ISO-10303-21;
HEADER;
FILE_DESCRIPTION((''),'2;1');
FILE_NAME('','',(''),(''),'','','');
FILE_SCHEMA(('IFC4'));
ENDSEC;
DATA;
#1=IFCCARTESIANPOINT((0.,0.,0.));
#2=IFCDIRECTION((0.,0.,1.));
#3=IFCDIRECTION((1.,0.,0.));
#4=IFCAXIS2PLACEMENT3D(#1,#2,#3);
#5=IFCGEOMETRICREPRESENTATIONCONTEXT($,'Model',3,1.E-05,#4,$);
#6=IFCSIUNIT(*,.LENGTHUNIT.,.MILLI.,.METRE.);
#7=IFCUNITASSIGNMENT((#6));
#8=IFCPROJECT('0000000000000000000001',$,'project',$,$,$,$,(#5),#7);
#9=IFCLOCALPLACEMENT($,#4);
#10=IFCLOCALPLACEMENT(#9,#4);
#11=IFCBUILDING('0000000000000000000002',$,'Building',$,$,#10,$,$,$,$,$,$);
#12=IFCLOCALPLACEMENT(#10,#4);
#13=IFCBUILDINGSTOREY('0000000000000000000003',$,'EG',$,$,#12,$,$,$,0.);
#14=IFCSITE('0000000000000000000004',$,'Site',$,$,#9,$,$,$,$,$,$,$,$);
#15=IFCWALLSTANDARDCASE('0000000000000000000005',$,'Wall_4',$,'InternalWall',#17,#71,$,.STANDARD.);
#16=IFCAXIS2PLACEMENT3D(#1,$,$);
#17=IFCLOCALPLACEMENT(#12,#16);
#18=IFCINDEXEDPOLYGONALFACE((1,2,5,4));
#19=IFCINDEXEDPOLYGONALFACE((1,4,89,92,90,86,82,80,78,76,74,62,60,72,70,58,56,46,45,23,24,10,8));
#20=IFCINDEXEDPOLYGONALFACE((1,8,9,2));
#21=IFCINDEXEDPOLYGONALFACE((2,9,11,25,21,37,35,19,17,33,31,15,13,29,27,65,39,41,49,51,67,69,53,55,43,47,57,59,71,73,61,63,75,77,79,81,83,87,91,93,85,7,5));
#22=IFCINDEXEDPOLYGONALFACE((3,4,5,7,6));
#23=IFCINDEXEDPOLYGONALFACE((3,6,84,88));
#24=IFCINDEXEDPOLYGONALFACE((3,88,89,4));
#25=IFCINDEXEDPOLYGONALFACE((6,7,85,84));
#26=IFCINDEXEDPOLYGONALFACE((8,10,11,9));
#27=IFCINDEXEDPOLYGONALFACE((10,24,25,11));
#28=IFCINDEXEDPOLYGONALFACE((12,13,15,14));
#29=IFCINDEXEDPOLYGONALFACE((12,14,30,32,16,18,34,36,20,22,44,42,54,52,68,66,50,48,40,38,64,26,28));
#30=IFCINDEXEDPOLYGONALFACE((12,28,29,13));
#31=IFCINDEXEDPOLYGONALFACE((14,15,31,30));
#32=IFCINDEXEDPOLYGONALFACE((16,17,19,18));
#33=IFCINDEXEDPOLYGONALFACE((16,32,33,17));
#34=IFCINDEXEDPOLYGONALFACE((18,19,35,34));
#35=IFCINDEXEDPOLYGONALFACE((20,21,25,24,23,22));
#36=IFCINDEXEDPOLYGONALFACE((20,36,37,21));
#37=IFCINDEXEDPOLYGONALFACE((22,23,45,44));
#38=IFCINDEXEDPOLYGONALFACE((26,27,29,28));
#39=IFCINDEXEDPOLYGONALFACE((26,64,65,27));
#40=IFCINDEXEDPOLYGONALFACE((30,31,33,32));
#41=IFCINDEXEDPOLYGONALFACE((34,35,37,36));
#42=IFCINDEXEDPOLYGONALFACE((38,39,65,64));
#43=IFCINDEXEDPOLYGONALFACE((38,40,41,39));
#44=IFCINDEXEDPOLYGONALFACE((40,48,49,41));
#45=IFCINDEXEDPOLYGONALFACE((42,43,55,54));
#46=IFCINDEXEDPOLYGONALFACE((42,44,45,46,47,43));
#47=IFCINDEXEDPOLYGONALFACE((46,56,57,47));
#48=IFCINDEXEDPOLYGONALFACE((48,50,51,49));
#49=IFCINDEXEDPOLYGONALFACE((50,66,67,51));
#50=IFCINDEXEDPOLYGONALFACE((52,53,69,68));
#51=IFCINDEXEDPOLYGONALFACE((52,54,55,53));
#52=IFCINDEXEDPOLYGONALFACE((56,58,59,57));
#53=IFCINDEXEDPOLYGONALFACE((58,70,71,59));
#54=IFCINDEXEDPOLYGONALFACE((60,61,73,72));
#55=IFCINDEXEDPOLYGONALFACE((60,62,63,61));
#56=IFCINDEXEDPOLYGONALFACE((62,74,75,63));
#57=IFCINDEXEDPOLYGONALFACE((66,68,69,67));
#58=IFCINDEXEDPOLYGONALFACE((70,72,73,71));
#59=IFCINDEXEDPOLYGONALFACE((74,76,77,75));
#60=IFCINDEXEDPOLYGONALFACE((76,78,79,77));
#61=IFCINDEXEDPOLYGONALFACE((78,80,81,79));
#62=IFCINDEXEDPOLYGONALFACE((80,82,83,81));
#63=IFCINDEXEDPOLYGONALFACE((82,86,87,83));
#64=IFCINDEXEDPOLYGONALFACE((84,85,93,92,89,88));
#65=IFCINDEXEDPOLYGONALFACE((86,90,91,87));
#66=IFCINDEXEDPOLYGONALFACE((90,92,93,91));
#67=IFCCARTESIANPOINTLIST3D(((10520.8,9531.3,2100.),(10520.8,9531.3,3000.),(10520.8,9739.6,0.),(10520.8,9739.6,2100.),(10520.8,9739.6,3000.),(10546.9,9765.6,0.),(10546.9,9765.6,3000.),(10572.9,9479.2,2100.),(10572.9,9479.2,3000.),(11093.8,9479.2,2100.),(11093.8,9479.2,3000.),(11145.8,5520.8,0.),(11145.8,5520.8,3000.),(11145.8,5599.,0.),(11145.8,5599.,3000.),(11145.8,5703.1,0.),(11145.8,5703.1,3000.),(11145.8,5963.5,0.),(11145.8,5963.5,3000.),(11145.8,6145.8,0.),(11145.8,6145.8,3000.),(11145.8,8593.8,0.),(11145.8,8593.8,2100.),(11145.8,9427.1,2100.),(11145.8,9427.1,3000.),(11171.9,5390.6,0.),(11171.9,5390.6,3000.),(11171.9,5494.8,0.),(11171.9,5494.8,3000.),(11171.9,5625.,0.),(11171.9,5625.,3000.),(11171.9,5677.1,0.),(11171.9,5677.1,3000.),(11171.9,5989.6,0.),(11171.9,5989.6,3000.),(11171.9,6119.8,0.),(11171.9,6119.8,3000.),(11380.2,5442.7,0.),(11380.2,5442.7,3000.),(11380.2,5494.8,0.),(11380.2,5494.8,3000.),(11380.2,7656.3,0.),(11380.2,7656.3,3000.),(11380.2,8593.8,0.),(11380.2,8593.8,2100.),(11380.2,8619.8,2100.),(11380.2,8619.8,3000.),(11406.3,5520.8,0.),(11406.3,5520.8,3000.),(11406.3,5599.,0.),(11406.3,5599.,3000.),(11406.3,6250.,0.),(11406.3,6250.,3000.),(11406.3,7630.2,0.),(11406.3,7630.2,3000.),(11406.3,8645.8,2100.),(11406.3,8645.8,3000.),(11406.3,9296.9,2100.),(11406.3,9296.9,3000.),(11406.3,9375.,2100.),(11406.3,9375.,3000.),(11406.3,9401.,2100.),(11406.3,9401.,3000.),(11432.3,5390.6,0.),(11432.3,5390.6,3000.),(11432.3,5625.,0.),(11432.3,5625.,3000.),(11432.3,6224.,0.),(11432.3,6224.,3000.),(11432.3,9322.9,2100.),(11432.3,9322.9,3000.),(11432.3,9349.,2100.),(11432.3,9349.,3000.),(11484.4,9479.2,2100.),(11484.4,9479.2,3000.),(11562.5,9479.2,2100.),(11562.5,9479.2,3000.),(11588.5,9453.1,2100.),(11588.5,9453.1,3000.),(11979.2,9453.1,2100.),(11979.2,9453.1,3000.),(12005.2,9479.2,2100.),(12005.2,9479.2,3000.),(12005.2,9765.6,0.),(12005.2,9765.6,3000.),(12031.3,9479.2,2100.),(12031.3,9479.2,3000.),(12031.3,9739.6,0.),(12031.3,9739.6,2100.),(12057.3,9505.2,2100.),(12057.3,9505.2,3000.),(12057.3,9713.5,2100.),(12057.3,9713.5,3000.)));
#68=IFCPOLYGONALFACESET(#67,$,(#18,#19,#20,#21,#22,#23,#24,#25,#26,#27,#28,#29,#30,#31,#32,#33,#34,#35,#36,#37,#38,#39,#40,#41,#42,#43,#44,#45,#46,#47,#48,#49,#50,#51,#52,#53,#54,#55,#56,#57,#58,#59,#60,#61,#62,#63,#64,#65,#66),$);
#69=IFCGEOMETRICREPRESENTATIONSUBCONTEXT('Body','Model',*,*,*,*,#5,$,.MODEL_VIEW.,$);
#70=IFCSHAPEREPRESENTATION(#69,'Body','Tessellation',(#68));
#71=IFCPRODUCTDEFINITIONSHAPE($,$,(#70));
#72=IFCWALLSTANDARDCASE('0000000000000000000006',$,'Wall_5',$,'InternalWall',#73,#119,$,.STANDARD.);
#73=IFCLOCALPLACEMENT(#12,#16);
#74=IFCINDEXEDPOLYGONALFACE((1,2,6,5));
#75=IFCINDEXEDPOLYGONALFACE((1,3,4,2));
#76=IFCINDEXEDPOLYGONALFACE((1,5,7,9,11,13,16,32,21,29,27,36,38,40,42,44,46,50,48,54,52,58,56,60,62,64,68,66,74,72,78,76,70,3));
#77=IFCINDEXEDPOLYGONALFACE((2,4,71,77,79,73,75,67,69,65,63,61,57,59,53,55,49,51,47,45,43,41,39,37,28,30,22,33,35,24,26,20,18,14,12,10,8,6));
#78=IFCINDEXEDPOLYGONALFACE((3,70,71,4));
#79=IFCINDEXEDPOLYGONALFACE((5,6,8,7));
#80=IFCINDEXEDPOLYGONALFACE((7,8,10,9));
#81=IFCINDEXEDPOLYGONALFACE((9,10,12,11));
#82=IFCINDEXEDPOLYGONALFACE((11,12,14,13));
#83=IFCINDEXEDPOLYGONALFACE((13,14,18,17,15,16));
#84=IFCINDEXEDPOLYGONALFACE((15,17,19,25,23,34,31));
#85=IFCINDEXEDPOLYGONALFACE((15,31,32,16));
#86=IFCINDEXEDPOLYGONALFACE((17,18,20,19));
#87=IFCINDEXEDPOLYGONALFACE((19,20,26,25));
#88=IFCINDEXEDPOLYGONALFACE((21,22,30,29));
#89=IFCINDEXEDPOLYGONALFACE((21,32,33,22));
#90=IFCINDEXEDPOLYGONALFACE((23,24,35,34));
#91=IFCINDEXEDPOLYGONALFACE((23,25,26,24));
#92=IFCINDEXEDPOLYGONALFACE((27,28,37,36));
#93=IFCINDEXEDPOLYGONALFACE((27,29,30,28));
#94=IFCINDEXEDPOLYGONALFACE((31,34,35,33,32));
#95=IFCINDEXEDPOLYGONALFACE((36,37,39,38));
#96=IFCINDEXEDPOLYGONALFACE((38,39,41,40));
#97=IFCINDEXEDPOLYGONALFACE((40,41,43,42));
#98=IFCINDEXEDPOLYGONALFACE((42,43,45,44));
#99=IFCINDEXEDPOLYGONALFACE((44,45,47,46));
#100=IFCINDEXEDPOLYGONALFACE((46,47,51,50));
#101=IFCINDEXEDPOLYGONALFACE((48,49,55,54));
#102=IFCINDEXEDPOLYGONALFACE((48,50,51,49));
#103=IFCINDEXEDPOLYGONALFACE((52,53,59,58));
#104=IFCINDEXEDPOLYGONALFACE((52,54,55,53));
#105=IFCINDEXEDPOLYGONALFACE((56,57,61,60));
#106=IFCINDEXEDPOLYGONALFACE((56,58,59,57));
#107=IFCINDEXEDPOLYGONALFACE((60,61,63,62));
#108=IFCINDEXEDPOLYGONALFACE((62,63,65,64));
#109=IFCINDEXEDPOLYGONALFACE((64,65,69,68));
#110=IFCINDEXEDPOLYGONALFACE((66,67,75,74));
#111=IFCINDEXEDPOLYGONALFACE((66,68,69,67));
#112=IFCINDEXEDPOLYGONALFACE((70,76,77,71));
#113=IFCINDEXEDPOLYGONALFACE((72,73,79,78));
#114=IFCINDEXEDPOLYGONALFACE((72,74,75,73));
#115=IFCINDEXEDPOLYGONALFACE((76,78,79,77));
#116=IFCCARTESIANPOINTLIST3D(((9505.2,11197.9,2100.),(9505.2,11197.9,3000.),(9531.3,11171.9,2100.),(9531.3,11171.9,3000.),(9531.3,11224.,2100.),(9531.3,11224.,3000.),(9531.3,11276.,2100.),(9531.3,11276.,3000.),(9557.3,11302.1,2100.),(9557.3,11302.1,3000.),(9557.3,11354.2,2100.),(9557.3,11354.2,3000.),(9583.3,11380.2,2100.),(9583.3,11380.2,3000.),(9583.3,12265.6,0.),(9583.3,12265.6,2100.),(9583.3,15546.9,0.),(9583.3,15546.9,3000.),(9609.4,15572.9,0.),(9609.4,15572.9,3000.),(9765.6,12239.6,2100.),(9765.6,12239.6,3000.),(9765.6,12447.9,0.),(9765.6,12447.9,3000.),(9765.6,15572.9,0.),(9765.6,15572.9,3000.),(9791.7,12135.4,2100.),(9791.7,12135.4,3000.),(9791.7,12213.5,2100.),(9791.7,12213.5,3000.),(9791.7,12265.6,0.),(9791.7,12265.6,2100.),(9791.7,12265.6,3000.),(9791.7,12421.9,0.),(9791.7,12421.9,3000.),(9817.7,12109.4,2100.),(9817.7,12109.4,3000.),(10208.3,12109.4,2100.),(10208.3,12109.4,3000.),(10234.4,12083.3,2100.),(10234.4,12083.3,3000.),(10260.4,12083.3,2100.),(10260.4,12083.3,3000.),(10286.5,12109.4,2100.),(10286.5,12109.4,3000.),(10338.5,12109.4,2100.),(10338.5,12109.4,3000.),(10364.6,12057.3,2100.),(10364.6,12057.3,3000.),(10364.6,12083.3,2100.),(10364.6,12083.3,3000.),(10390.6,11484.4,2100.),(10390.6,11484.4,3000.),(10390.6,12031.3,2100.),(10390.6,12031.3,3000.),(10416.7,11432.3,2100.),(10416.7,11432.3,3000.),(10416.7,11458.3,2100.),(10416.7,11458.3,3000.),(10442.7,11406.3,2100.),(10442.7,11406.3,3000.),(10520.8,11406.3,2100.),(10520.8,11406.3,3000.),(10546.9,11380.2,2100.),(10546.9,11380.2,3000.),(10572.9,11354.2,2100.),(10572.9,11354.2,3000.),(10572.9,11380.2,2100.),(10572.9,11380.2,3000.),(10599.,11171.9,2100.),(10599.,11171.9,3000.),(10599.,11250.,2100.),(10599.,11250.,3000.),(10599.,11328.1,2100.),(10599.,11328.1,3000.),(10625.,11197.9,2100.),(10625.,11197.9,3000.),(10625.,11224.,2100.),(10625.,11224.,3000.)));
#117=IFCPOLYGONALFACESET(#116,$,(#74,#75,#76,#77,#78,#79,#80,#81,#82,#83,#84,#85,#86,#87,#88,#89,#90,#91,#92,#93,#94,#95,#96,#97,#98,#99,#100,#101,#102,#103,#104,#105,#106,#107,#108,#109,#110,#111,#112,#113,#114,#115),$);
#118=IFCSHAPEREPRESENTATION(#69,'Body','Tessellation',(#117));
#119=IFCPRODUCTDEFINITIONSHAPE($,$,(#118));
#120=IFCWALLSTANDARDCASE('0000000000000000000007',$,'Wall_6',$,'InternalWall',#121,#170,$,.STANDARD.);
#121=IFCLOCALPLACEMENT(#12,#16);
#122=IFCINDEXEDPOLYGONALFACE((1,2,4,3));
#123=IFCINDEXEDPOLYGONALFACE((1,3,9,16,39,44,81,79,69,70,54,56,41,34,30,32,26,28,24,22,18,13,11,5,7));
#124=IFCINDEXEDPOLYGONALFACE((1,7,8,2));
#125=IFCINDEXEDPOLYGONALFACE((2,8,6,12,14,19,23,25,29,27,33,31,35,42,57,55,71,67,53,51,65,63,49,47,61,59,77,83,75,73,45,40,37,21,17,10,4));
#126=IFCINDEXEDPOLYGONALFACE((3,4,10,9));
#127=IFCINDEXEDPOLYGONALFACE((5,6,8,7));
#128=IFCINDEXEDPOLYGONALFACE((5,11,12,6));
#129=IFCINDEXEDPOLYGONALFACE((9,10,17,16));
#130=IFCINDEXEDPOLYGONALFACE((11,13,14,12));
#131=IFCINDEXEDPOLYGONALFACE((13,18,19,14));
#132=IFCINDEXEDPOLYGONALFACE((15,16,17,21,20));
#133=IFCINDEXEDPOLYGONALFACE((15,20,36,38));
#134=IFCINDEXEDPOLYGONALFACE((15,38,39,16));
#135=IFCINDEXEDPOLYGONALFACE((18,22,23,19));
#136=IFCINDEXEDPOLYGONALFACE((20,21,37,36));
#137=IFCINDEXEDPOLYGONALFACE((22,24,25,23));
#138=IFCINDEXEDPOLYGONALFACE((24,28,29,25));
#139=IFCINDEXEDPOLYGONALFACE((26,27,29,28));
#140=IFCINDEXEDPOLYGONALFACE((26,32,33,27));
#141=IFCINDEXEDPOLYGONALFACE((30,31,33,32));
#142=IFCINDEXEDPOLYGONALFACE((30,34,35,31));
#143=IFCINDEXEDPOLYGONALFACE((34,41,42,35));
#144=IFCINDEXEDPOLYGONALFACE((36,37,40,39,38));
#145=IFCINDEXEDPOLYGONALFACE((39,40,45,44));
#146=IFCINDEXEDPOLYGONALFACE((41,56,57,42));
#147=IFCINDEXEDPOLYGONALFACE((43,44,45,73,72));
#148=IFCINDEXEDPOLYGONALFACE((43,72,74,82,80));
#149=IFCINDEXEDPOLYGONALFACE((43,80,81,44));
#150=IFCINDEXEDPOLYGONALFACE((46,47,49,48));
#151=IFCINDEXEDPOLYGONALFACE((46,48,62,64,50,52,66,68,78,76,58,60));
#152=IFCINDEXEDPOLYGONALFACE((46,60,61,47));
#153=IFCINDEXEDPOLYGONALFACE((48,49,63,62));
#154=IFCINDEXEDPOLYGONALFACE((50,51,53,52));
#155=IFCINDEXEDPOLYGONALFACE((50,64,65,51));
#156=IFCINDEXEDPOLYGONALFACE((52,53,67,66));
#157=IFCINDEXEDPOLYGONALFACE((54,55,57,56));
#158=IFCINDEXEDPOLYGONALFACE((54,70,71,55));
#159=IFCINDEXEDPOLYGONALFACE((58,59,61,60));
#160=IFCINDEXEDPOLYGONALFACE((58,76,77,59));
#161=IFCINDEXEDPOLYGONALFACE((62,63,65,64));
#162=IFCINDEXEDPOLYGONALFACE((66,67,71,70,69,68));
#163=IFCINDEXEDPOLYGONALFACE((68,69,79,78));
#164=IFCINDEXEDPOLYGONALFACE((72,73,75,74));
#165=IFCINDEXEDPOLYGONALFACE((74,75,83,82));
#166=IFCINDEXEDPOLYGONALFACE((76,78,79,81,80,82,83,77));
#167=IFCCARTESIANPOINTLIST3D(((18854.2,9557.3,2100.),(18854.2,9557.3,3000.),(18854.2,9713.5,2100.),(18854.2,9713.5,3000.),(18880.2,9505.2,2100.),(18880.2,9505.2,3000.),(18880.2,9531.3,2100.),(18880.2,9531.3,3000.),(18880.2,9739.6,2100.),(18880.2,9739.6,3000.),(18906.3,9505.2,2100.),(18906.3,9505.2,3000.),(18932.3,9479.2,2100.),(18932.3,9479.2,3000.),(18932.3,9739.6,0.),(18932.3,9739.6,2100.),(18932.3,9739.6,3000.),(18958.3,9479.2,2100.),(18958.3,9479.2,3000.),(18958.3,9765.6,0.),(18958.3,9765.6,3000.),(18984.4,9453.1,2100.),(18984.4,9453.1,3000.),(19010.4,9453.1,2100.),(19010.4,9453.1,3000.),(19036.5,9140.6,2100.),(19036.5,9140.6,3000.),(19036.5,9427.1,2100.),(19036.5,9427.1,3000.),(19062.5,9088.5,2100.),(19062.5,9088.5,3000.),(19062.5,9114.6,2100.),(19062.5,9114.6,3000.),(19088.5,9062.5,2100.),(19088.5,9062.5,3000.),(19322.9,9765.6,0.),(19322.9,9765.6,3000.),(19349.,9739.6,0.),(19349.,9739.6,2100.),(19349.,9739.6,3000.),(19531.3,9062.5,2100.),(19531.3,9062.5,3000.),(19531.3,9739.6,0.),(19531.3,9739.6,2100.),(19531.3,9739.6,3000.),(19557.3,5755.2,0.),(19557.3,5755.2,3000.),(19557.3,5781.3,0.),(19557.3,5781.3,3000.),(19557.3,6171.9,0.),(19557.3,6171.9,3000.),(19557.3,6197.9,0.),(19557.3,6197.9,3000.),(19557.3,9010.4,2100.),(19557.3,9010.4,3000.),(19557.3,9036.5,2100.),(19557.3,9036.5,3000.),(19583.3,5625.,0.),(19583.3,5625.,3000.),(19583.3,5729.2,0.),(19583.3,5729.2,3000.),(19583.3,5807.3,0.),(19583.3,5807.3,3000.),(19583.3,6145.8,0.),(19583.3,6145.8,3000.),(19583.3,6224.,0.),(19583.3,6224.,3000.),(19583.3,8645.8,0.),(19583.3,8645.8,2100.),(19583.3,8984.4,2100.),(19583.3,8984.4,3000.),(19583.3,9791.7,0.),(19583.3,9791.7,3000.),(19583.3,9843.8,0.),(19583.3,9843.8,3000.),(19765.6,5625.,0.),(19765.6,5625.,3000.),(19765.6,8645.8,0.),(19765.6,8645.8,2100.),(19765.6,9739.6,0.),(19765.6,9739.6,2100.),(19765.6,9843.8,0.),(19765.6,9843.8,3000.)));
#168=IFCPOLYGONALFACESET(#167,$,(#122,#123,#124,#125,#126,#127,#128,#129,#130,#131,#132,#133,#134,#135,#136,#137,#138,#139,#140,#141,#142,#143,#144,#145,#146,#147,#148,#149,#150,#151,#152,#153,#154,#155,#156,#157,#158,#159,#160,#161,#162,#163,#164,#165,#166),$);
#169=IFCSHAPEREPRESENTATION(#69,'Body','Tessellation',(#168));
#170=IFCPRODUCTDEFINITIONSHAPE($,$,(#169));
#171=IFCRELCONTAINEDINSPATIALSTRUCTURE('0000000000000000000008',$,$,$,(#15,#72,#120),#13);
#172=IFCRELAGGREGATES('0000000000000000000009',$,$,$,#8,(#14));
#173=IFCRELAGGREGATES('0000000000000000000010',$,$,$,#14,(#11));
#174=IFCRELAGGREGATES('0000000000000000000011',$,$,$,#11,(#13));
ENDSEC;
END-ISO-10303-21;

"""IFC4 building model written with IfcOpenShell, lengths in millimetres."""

from ifc_helpers import new_model, si_unit, frame, origin_with_axes, place, context, subcontext, project, spatial, polyline, rectangle, outline, extrude, element, save


model = new_model("IFC4")

# Units and contexts
model_context = context("Model", 3, precision=1e-05, world=origin_with_axes())
body_context = subcontext(model_context, "Body", "Model", "MODEL_VIEW")
ifc_project = project(units=[si_unit("LENGTHUNIT", "METRE", prefix="MILLI")], contexts=[model_context])

# Site, building, storey
site_placement = place(None, origin_with_axes())
site = spatial("IfcSite", under=ifc_project, at=site_placement, Name="Site")
building_placement = place(site_placement, origin_with_axes())
building = spatial("IfcBuilding", under=site, at=building_placement, Name="Building")
storey_placement = place(building_placement, origin_with_axes())
storey = spatial("IfcBuildingStorey", under=building, at=storey_placement, Name="EG", Elevation=0.0)

# Walls, openings
wall_1_placement = place(storey_placement, origin_with_axes())
wall_1 = element("IfcWallStandardCase", 1, at=wall_1_placement, inside=storey, Name="Wall_4", ObjectType="InternalWall", PredefinedType="STANDARD", context=body_context, shape_type="SweptSolid", body=[
    extrude(outline(polyline([(11171.9, 5390.6, 0.0), (11171.9, 5494.8, 0.0), (11145.8, 5520.8, 0.0), (11145.8, 5599.0, 0.0), (11171.9, 5625.0, 0.0), (11171.9, 5677.1, 0.0), (11145.8, 5703.1, 0.0), (11145.8, 5963.5, 0.0), (11171.9, 5989.6, 0.0), (11171.9, 6119.8, 0.0), (11145.8, 6145.8, 0.0), (11145.8, 9427.1, 0.0), (11093.8, 9479.2, 0.0), (10572.9, 9479.2, 0.0), (10520.8, 9531.3, 0.0), (10520.8, 9739.6, 0.0), (10546.9, 9765.6, 0.0), (12005.2, 9765.6, 0.0), (12057.3, 9713.5, 0.0), (12057.3, 9505.2, 0.0), (12031.3, 9479.2, 0.0), (12005.2, 9479.2, 0.0), (11979.2, 9453.1, 0.0), (11588.5, 9453.1, 0.0), (11562.5, 9479.2, 0.0), (11484.4, 9479.2, 0.0), (11406.3, 9401.0, 0.0), (11406.3, 9375.0, 0.0), (11432.3, 9349.0, 0.0), (11432.3, 9322.9, 0.0), (11406.3, 9296.9, 0.0), (11406.3, 8645.8, 0.0), (11380.2, 8619.8, 0.0), (11380.2, 7656.3, 0.0), (11406.3, 7630.2, 0.0), (11406.3, 6250.0, 0.0), (11432.3, 6224.0, 0.0), (11432.3, 5625.0, 0.0), (11406.3, 5599.0, 0.0), (11406.3, 5520.8, 0.0), (11380.2, 5494.8, 0.0), (11380.2, 5442.7, 0.0), (11432.3, 5390.6, 0.0), (11562.5, 5390.6, 0.0), (11171.9, 5390.6, 0.0)])), origin_with_axes(), (0.0, 0.0, 1.0), 3000.0),
])
opening_1_placement = place(wall_1_placement, origin_with_axes())
element("IfcOpeningElement", 2, at=opening_1_placement, inside=storey, cuts=wall_1, context=body_context, shape_type="SweptSolid", body=[
    extrude(rectangle(XDim=1145.8, YDim=1536.5), frame((11289.1, 9166.7, 0.0), z_axis=(0.0, 0.0, 1.0), x_axis=(0.0, 1.0, 0.0)), (0.0, 0.0, 1.0), 2100.0),
])
wall_2_placement = place(storey_placement, origin_with_axes())
wall_2 = element("IfcWallStandardCase", 3, at=wall_2_placement, inside=storey, Name="Wall_5", ObjectType="InternalWall", PredefinedType="STANDARD", context=body_context, shape_type="SweptSolid", body=[
    extrude(outline(polyline([(9531.3, 11171.9, 0.0), (9505.2, 11197.9, 0.0), (9531.3, 11224.0, 0.0), (9531.3, 11276.0, 0.0), (9557.3, 11302.1, 0.0), (9557.3, 11354.2, 0.0), (9583.3, 11380.2, 0.0), (9583.3, 15546.9, 0.0), (9609.4, 15572.9, 0.0), (9765.6, 15572.9, 0.0), (9765.6, 12447.9, 0.0), (9791.7, 12421.9, 0.0), (9791.7, 12265.6, 0.0), (9765.6, 12239.6, 0.0), (9791.7, 12213.5, 0.0), (9791.7, 12135.4, 0.0), (9817.7, 12109.4, 0.0), (10208.3, 12109.4, 0.0), (10234.4, 12083.3, 0.0), (10260.4, 12083.3, 0.0), (10286.5, 12109.4, 0.0), (10338.5, 12109.4, 0.0), (10364.6, 12083.3, 0.0), (10364.6, 12057.3, 0.0), (10390.6, 12031.3, 0.0), (10390.6, 11484.4, 0.0), (10416.7, 11458.3, 0.0), (10416.7, 11432.3, 0.0), (10442.7, 11406.3, 0.0), (10520.8, 11406.3, 0.0), (10546.9, 11380.2, 0.0), (10572.9, 11380.2, 0.0), (10572.9, 11354.2, 0.0), (10599.0, 11328.1, 0.0), (10599.0, 11250.0, 0.0), (10625.0, 11224.0, 0.0), (10625.0, 11197.9, 0.0), (10599.0, 11171.9, 0.0), (9531.3, 11171.9, 0.0)])), origin_with_axes(), (0.0, 0.0, 1.0), 3000.0),
])
opening_2_placement = place(wall_2_placement, origin_with_axes())
element("IfcOpeningElement", 4, at=opening_2_placement, inside=storey, cuts=wall_2, context=body_context, shape_type="SweptSolid", body=[
    extrude(rectangle(XDim=1093.8, YDim=1119.8), frame((10065.1, 11718.8, 0.0), z_axis=(0.0, 0.0, 1.0), x_axis=(0.0, -1.0, 0.0)), (0.0, 0.0, 1.0), 2100.0),
])
wall_3_placement = place(storey_placement, origin_with_axes())
wall_3 = element("IfcWallStandardCase", 5, at=wall_3_placement, inside=storey, Name="Wall_6", ObjectType="InternalWall", PredefinedType="STANDARD", context=body_context, shape_type="SweptSolid", body=[
    extrude(outline(polyline([(19583.3, 5625.0, 0.0), (19583.3, 5729.2, 0.0), (19557.3, 5755.2, 0.0), (19557.3, 5781.3, 0.0), (19583.3, 5807.3, 0.0), (19583.3, 6145.8, 0.0), (19557.3, 6171.9, 0.0), (19557.3, 6197.9, 0.0), (19583.3, 6224.0, 0.0), (19583.3, 8984.4, 0.0), (19557.3, 9010.4, 0.0), (19557.3, 9036.5, 0.0), (19531.3, 9062.5, 0.0), (19088.5, 9062.5, 0.0), (19062.5, 9088.5, 0.0), (19062.5, 9114.6, 0.0), (19036.5, 9140.6, 0.0), (19036.5, 9427.1, 0.0), (19010.4, 9453.1, 0.0), (18984.4, 9453.1, 0.0), (18958.3, 9479.2, 0.0), (18932.3, 9479.2, 0.0), (18906.3, 9505.2, 0.0), (18880.2, 9505.2, 0.0), (18880.2, 9531.3, 0.0), (18854.2, 9557.3, 0.0), (18854.2, 9713.5, 0.0), (18880.2, 9739.6, 0.0), (18932.3, 9739.6, 0.0), (18958.3, 9765.6, 0.0), (19322.9, 9765.6, 0.0), (19349.0, 9739.6, 0.0), (19531.3, 9739.6, 0.0), (19583.3, 9791.7, 0.0), (19583.3, 9843.8, 0.0), (19765.6, 9843.8, 0.0), (19765.6, 5625.0, 0.0), (19583.3, 5625.0, 0.0)])), origin_with_axes(), (0.0, 0.0, 1.0), 3000.0),
])
opening_3_placement = place(wall_3_placement, origin_with_axes())
element("IfcOpeningElement", 6, at=opening_3_placement, inside=storey, cuts=wall_3, context=body_context, shape_type="SweptSolid", body=[
    extrude(rectangle(XDim=1093.8, YDim=911.5), frame((19309.9, 9192.7, 0.0), z_axis=(0.0, 0.0, 1.0), x_axis=(0.0, 1.0, 0.0)), (0.0, 0.0, 1.0), 2100.0),
])

save(model, "model.ifc")
